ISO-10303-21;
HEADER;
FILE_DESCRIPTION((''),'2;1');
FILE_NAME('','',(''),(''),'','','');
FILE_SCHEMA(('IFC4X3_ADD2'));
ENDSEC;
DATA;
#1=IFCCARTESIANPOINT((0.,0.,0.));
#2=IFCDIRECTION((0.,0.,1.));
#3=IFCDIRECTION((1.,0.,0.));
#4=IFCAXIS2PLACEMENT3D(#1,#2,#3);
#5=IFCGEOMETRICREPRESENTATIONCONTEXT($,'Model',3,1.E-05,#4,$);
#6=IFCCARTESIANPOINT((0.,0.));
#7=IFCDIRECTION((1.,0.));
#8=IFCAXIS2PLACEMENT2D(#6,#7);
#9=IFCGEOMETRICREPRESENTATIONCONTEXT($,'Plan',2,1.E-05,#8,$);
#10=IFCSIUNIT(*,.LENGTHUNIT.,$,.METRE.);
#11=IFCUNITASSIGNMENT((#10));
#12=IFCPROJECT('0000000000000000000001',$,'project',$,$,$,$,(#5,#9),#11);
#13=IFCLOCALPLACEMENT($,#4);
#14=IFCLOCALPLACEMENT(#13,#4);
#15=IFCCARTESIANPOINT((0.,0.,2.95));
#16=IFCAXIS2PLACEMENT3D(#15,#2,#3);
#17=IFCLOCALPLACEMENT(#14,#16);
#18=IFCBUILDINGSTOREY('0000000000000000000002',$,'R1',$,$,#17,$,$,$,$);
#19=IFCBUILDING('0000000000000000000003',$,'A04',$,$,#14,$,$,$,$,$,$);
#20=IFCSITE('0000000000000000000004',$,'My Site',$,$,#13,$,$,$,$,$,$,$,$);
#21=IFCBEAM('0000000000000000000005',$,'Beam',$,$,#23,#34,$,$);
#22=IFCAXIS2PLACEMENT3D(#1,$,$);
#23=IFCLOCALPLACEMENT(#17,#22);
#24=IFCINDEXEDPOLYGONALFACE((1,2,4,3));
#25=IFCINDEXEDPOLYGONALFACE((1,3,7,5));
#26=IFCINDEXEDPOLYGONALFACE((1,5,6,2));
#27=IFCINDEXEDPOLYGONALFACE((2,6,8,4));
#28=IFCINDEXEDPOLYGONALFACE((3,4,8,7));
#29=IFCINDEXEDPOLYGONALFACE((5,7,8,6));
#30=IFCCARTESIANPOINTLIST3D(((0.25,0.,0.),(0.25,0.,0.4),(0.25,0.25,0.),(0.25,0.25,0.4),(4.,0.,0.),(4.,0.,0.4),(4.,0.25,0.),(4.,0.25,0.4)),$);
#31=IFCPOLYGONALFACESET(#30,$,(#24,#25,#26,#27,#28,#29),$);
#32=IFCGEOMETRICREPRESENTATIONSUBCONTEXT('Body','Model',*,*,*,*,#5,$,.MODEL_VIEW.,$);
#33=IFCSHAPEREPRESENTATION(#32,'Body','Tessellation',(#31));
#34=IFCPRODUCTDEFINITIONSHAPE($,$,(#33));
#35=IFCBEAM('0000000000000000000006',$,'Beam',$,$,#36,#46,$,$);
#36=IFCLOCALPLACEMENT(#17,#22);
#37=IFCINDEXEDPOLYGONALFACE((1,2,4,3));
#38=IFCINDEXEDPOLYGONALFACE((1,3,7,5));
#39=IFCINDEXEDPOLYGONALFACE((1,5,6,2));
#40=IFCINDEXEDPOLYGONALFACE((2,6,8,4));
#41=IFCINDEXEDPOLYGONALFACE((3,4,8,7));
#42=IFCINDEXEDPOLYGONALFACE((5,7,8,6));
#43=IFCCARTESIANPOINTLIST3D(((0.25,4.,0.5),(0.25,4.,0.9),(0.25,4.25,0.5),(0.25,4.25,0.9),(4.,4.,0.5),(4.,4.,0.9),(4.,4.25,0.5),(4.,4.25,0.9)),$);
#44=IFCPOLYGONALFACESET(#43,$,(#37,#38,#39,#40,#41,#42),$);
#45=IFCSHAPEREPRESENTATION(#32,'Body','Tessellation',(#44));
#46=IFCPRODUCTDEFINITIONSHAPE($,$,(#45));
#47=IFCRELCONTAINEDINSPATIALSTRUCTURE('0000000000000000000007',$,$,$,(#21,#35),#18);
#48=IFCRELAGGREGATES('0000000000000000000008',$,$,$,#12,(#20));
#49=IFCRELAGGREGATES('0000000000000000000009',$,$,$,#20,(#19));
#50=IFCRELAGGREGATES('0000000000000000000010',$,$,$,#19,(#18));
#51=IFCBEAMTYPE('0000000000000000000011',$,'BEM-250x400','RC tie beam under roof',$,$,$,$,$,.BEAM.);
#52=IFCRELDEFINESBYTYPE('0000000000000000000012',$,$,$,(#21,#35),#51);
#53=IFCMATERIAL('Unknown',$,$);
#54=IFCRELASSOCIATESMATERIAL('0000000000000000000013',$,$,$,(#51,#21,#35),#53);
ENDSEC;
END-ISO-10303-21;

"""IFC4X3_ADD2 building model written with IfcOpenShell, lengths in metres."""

from ifc_helpers import new_model, si_unit, frame, origin_with_axes, origin_2d_with_axis, place, context, subcontext, project, spatial, rectangle, extrude, material, material_profile, profile_set, profile_usage, type_object, element, save


model = new_model("IFC4X3_ADD2")

# Units and contexts
model_context = context("Model", 3, precision=1e-05, world=origin_with_axes())
plan_context = context("Plan", 2, precision=1e-05, world=origin_2d_with_axis())
body_context = subcontext(model_context, "Body", "Model", "MODEL_VIEW")
ifc_project = project(units=[si_unit("LENGTHUNIT", "METRE")], contexts=[model_context, plan_context])

# Site, building, storey
site_placement = place(None, origin_with_axes())
site = spatial("IfcSite", under=ifc_project, at=site_placement, Name="My Site")
building_placement = place(site_placement, origin_with_axes())
building = spatial("IfcBuilding", under=site, at=building_placement, Name="A04")
storey_placement = place(building_placement, frame((0.0, 0.0, 2.95), z_axis=(0.0, 0.0, 1.0), x_axis=(1.0, 0.0, 0.0)))
storey = spatial("IfcBuildingStorey", under=building, at=storey_placement, Name="R1")

# Beams
ifc_material = material(Name="Unknown")
ifc_material_profile = material_profile(ifc_material, rectangle(XDim=0.25, YDim=0.4))
ifc_profile_set = profile_set([ifc_material_profile])
ifc_profile_usage_1 = profile_usage(ifc_profile_set, cardinal=8)
beam_type = type_object("IfcBeamType", Name="BEM-250x400", Description="RC tie beam under roof", PredefinedType="BEAM", material=ifc_profile_set)
beam_1_placement = place(storey_placement, frame((4.0, 0.125, 0.4), z_axis=(-1.0, 0.0, 0.0), x_axis=(0.0, -1.0, 0.0)))
element("IfcBeam", 1, at=beam_1_placement, inside=storey, type_object=beam_type, material=ifc_profile_usage_1, Name="Beam", context=body_context, shape_type="SweptSolid", body=[
    extrude(rectangle(XDim=0.25, YDim=0.4), frame((0.0, -0.2, 0.0), z_axis=(0.0, 0.0, 1.0), x_axis=(1.0, 0.0, 0.0)), (0.0, 0.0, 1.0), 3.75),
])
ifc_profile_usage_2 = profile_usage(ifc_profile_set, cardinal=8)
beam_2_placement = place(storey_placement, frame((4.0, 4.125, 0.9), z_axis=(-1.0, 0.0, 0.0), x_axis=(0.0, -1.0, 0.0)))
element("IfcBeam", 2, at=beam_2_placement, inside=storey, type_object=beam_type, material=ifc_profile_usage_2, Name="Beam", context=body_context, shape_type="SweptSolid", body=[
    extrude(rectangle(XDim=0.25, YDim=0.4), frame((0.0, -0.2, 0.0), z_axis=(0.0, 0.0, 1.0), x_axis=(1.0, 0.0, 0.0)), (0.0, 0.0, 1.0), 3.75),
])

save(model, "model.ifc")
